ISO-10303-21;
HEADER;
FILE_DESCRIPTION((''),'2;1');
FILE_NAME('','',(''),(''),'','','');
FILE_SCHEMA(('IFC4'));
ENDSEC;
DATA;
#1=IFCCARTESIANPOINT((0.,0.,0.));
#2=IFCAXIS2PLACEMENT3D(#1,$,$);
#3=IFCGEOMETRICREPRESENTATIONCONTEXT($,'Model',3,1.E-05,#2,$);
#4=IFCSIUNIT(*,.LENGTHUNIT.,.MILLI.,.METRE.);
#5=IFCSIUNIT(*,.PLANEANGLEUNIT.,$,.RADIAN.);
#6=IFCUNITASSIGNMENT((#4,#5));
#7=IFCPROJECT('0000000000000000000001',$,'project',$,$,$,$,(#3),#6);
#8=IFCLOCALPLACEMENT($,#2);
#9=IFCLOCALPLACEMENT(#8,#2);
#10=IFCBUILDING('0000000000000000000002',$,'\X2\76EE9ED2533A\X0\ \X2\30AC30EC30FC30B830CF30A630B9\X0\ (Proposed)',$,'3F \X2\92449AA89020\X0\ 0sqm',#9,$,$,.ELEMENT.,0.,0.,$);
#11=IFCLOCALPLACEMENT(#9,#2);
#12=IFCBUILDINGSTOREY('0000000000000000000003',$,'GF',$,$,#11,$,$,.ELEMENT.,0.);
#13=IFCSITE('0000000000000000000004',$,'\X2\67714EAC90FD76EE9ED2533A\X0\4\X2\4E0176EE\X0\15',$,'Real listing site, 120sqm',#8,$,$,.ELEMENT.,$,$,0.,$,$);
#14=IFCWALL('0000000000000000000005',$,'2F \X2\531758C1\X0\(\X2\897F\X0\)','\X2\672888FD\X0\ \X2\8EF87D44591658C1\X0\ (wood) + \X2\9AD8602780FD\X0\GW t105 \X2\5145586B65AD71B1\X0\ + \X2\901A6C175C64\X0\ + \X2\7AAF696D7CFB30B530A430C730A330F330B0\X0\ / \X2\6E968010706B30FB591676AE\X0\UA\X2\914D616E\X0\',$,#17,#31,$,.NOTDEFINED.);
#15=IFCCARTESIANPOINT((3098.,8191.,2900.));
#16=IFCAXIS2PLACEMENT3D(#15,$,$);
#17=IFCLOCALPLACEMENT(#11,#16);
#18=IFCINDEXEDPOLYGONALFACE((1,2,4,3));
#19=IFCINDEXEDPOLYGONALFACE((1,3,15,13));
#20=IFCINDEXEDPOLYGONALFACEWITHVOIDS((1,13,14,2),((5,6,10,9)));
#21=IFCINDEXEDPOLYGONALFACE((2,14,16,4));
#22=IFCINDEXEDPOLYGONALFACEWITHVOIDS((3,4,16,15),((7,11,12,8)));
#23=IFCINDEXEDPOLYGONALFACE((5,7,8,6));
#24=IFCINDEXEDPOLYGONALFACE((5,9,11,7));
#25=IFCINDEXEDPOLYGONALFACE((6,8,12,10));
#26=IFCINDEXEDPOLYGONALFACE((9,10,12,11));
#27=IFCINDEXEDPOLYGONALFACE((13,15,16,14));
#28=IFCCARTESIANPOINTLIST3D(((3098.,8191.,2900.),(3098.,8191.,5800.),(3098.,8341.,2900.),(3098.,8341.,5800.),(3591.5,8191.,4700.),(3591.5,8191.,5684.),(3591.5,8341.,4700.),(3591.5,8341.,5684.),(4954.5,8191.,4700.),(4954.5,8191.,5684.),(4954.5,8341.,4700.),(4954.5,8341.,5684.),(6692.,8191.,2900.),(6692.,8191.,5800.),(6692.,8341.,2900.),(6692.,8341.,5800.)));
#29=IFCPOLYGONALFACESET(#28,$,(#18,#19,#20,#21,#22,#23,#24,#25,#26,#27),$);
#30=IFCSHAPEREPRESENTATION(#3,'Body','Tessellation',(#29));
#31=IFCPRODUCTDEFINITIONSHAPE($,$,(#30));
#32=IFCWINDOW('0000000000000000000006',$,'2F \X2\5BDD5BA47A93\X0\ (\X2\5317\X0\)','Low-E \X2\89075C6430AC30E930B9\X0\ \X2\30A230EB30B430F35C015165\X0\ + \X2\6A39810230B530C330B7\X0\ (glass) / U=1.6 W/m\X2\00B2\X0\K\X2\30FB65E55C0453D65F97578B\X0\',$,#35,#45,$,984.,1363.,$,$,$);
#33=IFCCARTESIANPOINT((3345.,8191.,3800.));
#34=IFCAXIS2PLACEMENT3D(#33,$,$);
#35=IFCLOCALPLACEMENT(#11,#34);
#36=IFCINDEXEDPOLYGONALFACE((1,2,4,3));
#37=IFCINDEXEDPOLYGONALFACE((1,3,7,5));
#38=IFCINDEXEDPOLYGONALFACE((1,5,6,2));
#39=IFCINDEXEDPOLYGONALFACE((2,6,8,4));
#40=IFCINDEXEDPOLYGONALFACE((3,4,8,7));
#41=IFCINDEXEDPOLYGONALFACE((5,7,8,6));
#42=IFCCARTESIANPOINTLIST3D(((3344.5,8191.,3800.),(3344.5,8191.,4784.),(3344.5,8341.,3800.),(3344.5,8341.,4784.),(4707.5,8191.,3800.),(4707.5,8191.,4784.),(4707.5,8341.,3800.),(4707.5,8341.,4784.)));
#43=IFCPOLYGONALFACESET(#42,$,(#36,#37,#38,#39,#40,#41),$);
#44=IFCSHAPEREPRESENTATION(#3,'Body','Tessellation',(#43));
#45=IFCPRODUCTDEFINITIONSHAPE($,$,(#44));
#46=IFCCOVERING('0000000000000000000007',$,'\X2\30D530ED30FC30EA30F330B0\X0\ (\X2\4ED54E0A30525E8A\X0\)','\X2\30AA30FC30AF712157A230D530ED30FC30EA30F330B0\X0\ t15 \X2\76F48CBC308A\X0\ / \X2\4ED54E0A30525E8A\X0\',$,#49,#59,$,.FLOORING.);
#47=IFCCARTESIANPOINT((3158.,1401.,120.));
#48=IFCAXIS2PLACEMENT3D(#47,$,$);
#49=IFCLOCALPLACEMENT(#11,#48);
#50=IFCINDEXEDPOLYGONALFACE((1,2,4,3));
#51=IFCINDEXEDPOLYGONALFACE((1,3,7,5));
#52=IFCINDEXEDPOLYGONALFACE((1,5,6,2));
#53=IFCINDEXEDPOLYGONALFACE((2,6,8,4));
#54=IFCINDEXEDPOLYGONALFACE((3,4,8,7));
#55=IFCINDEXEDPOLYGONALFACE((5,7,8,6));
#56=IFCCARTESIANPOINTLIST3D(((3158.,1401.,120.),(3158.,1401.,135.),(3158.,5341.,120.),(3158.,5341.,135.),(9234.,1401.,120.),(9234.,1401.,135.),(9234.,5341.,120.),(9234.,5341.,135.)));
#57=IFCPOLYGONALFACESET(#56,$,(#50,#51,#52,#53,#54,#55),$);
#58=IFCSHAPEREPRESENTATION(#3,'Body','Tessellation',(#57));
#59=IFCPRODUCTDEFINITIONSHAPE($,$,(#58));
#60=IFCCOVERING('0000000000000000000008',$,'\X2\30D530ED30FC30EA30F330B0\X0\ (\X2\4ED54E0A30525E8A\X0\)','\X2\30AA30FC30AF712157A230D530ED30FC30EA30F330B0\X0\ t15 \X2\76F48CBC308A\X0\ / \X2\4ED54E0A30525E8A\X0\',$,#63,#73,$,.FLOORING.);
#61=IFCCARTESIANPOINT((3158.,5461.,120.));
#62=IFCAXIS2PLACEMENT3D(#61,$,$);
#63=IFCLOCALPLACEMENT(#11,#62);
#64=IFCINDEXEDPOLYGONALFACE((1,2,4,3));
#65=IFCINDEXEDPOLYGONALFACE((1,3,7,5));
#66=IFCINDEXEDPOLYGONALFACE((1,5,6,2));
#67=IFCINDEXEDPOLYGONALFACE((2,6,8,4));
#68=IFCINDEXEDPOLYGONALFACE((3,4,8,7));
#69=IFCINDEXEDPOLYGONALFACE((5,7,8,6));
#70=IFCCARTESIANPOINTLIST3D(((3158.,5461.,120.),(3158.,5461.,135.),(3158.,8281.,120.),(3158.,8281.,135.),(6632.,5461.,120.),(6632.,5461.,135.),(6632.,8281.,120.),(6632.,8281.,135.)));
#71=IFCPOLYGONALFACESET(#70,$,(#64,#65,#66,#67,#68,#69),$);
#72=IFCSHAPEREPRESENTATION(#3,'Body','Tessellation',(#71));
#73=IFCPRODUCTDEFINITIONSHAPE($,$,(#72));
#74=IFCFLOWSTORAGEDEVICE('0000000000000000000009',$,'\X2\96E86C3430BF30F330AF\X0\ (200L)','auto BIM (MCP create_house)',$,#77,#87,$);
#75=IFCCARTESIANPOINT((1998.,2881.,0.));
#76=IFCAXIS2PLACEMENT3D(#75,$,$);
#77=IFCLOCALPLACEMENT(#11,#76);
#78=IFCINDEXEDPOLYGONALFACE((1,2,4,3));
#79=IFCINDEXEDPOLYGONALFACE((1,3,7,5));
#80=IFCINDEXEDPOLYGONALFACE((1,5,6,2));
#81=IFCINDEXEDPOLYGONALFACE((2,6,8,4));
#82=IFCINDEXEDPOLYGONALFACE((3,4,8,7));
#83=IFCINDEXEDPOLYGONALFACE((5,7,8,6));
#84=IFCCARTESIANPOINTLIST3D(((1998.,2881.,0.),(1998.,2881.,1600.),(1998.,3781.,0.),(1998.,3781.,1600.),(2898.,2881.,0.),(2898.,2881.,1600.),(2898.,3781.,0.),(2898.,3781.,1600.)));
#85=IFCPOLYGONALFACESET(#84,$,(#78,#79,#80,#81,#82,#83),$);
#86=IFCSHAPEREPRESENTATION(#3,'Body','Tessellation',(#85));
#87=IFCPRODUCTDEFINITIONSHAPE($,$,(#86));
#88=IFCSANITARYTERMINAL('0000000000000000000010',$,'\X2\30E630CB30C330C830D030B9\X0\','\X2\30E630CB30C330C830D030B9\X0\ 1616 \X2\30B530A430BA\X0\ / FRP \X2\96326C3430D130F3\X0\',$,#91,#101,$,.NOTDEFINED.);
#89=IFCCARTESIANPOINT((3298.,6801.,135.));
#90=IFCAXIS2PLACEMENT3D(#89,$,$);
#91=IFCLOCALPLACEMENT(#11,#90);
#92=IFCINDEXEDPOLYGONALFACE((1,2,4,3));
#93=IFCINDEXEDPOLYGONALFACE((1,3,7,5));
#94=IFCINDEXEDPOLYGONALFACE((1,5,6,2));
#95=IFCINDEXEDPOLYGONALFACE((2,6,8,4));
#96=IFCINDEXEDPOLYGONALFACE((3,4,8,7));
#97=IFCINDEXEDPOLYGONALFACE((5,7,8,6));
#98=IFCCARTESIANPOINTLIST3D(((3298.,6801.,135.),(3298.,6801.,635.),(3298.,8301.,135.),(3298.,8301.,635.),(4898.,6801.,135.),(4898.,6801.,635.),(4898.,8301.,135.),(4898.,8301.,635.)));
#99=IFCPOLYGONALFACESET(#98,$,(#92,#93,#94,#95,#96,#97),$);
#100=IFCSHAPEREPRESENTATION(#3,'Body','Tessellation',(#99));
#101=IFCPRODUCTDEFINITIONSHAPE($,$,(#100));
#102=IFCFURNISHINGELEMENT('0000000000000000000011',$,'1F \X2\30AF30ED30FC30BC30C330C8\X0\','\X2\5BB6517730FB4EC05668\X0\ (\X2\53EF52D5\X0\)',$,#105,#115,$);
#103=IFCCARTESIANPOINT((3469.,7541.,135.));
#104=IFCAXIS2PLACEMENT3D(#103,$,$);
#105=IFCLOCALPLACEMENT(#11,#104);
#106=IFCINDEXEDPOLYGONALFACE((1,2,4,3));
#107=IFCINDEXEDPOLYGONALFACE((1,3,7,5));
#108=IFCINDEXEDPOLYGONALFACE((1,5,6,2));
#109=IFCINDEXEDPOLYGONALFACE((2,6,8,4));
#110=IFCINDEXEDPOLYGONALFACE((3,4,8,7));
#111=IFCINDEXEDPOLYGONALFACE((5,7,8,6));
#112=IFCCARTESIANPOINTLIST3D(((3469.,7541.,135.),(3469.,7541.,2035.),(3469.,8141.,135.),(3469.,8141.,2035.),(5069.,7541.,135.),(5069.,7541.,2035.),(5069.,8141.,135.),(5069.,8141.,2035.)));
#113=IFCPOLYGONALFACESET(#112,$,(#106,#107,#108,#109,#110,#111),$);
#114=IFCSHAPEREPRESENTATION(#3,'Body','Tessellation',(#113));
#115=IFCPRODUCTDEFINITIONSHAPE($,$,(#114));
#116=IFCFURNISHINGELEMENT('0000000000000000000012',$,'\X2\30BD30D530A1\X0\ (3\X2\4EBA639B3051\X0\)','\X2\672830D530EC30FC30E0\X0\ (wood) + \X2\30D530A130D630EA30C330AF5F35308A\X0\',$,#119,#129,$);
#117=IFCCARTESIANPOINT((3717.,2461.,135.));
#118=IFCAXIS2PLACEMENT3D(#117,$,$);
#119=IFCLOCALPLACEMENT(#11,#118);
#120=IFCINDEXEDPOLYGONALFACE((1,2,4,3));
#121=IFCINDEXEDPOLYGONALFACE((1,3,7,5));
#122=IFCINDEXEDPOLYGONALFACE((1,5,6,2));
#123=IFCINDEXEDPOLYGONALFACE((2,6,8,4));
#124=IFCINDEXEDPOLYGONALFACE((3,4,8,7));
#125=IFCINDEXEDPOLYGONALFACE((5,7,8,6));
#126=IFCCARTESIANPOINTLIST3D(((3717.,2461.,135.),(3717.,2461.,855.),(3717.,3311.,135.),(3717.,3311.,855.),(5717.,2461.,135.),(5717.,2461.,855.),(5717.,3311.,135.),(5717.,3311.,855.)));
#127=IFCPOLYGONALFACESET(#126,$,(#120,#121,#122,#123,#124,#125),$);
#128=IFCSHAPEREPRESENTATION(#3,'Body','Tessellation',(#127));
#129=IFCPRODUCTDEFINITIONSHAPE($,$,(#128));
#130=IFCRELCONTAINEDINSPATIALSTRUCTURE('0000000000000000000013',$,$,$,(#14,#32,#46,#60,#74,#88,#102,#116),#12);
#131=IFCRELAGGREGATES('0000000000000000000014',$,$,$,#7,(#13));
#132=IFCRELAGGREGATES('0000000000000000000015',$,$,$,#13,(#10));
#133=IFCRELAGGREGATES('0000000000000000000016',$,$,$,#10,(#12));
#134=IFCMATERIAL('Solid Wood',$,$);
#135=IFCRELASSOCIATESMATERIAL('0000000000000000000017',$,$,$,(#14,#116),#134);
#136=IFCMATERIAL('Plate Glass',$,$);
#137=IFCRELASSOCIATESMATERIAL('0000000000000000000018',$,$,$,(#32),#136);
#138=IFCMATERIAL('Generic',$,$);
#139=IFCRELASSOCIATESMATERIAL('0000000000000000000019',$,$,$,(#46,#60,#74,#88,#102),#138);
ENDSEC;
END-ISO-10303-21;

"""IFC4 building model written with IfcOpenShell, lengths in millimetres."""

from ifc_helpers import new_model, si_unit, frame, frame_2d, origin, place, context, project, spatial, rectangle, extrude, material, element, fill, save


model = new_model("IFC4")

# Units and contexts
model_context = context("Model", 3, precision=1e-05, world=origin())
ifc_project = project(units=[si_unit("LENGTHUNIT", "METRE", prefix="MILLI"), si_unit("PLANEANGLEUNIT", "RADIAN")], contexts=[model_context])

# Site, building, storey
site_placement = place(None, origin())
site = spatial("IfcSite", under=ifc_project, at=site_placement, Name="東京都目黒区4丁目15", ObjectType="Real listing site, 120sqm", CompositionType="ELEMENT", RefElevation=0.0)
building_placement = place(site_placement, origin())
building = spatial("IfcBuilding", under=site, at=building_placement, Name="目黒区 ガレージハウス (Proposed)", ObjectType="3F 鉄骨造 0sqm", CompositionType="ELEMENT", ElevationOfRefHeight=0.0, ElevationOfTerrain=0.0)
storey_placement = place(building_placement, origin())
storey = spatial("IfcBuildingStorey", under=building, at=storey_placement, Name="GF", CompositionType="ELEMENT", Elevation=0.0)

# Shared definitions
ifc_material_1 = material(Name="Solid Wood")

# Shared definitions
ifc_material_2 = material(Name="Plate Glass")

# Wall, opening, window
wall_1_placement = place(storey_placement, frame((3098.0, 8191.0, 2900.0)))
wall_1 = element("IfcWall", 1, at=wall_1_placement, inside=storey, material=ifc_material_1, Name="2F 北壁(西)", Description="木製 軸組外壁 (wood) + 高性能GW t105 充填断熱 + 通気層 + 窯業系サイディング / 準耐火・外皮UA配慮", PredefinedType="NOTDEFINED", context=model_context, shape_type="SweptSolid", body=[
    extrude(rectangle(XDim=3594.0, YDim=150.0, at=frame_2d((1797.0, 75.0))), frame((3098.0, 8191.0, 2900.0)), (0.0, 0.0, 1.0), 2900.0),
])
opening_1_placement = place(storey_placement, frame((3345.0, 8191.0, 3800.0)))
opening_1 = element("IfcOpeningElement", 2, at=opening_1_placement, cuts=wall_1, PredefinedType="NOTDEFINED", context=model_context, shape_type="SweptSolid", body=[
    extrude(rectangle(XDim=1363.0, YDim=150.0, at=frame_2d((681.0, 75.0))), frame((3345.0, 8191.0, 3800.0)), (0.0, 0.0, 1.0), 984.0),
])
window_1_placement = place(storey_placement, frame((3345.0, 8191.0, 3800.0)))
window_1 = element("IfcWindow", 3, at=window_1_placement, inside=storey, material=ifc_material_2, Name="2F 寝室窓 (北)", Description="Low-E 複層ガラス アルゴン封入 + 樹脂サッシ (glass) / U=1.6 W/m²K・日射取得型", OverallHeight=984.0, OverallWidth=1363.0, context=model_context, shape_type="SweptSolid", body=[
    extrude(rectangle(XDim=1363.0, YDim=150.0, at=frame_2d((681.0, 75.0))), frame((3345.0, 8191.0, 3800.0)), (0.0, 0.0, 1.0), 984.0),
])
fill(opening_1, window_1)

# Coverings
ifc_material_3 = material(Name="Generic")
covering_1_placement = place(storey_placement, frame((3158.0, 1401.0, 120.0)))
element("IfcCovering", 4, at=covering_1_placement, inside=storey, material=ifc_material_3, Name="フローリング (仕上げ床)", Description="オーク無垢フローリング t15 直貼り / 仕上げ床", PredefinedType="FLOORING", context=model_context, shape_type="SweptSolid", body=[
    extrude(rectangle(XDim=6076.0, YDim=3940.0, at=frame_2d((3038.0, 1970.0))), frame((3158.0, 1401.0, 120.0)), (0.0, 0.0, 1.0), 15.0),
])
covering_2_placement = place(storey_placement, frame((3158.0, 5461.0, 120.0)))
element("IfcCovering", 5, at=covering_2_placement, inside=storey, material=ifc_material_3, Name="フローリング (仕上げ床)", Description="オーク無垢フローリング t15 直貼り / 仕上げ床", PredefinedType="FLOORING", context=model_context, shape_type="SweptSolid", body=[
    extrude(rectangle(XDim=3474.0, YDim=2820.0, at=frame_2d((1737.0, 1410.0))), frame((3158.0, 5461.0, 120.0)), (0.0, 0.0, 1.0), 15.0),
])

# Flow storage device
flow_storage_device_placement = place(storey_placement, frame((1998.0, 2881.0, 0.0)))
element("IfcFlowStorageDevice", 6, at=flow_storage_device_placement, inside=storey, material=ifc_material_3, Name="雨水タンク (200L)", Description="auto BIM (MCP create_house)", context=model_context, shape_type="SweptSolid", body=[
    extrude(rectangle(XDim=900.0, YDim=900.0, at=frame_2d((450.0, 450.0))), frame((1998.0, 2881.0, 0.0)), (0.0, 0.0, 1.0), 1600.0),
])

# Sanitary terminal
sanitary_terminal_placement = place(storey_placement, frame((3298.0, 6801.0, 135.0)))
element("IfcSanitaryTerminal", 7, at=sanitary_terminal_placement, inside=storey, material=ifc_material_3, Name="ユニットバス", Description="ユニットバス 1616 サイズ / FRP 防水パン", PredefinedType="NOTDEFINED", context=model_context, shape_type="SweptSolid", body=[
    extrude(rectangle(XDim=1600.0, YDim=1500.0, at=frame_2d((800.0, 750.0))), frame((3298.0, 6801.0, 135.0)), (0.0, 0.0, 1.0), 500.0),
])

# Furnishing elements
furnishing_1_placement = place(storey_placement, frame((3469.0, 7541.0, 135.0)))
element("IfcFurnishingElement", 8, at=furnishing_1_placement, inside=storey, material=ifc_material_3, Name="1F クローゼット", Description="家具・什器 (可動)", context=model_context, shape_type="SweptSolid", body=[
    extrude(rectangle(XDim=1600.0, YDim=600.0, at=frame_2d((800.0, 300.0))), frame((3469.0, 7541.0, 135.0)), (0.0, 0.0, 1.0), 1900.0),
])
furnishing_2_placement = place(storey_placement, frame((3717.0, 2461.0, 135.0)))
element("IfcFurnishingElement", 9, at=furnishing_2_placement, inside=storey, material=ifc_material_1, Name="ソファ (3人掛け)", Description="木フレーム (wood) + ファブリック張り", context=model_context, shape_type="SweptSolid", body=[
    extrude(rectangle(XDim=2000.0, YDim=850.0, at=frame_2d((1000.0, 425.0))), frame((3717.0, 2461.0, 135.0)), (0.0, 0.0, 1.0), 720.0),
])

save(model, "model.ifc")
